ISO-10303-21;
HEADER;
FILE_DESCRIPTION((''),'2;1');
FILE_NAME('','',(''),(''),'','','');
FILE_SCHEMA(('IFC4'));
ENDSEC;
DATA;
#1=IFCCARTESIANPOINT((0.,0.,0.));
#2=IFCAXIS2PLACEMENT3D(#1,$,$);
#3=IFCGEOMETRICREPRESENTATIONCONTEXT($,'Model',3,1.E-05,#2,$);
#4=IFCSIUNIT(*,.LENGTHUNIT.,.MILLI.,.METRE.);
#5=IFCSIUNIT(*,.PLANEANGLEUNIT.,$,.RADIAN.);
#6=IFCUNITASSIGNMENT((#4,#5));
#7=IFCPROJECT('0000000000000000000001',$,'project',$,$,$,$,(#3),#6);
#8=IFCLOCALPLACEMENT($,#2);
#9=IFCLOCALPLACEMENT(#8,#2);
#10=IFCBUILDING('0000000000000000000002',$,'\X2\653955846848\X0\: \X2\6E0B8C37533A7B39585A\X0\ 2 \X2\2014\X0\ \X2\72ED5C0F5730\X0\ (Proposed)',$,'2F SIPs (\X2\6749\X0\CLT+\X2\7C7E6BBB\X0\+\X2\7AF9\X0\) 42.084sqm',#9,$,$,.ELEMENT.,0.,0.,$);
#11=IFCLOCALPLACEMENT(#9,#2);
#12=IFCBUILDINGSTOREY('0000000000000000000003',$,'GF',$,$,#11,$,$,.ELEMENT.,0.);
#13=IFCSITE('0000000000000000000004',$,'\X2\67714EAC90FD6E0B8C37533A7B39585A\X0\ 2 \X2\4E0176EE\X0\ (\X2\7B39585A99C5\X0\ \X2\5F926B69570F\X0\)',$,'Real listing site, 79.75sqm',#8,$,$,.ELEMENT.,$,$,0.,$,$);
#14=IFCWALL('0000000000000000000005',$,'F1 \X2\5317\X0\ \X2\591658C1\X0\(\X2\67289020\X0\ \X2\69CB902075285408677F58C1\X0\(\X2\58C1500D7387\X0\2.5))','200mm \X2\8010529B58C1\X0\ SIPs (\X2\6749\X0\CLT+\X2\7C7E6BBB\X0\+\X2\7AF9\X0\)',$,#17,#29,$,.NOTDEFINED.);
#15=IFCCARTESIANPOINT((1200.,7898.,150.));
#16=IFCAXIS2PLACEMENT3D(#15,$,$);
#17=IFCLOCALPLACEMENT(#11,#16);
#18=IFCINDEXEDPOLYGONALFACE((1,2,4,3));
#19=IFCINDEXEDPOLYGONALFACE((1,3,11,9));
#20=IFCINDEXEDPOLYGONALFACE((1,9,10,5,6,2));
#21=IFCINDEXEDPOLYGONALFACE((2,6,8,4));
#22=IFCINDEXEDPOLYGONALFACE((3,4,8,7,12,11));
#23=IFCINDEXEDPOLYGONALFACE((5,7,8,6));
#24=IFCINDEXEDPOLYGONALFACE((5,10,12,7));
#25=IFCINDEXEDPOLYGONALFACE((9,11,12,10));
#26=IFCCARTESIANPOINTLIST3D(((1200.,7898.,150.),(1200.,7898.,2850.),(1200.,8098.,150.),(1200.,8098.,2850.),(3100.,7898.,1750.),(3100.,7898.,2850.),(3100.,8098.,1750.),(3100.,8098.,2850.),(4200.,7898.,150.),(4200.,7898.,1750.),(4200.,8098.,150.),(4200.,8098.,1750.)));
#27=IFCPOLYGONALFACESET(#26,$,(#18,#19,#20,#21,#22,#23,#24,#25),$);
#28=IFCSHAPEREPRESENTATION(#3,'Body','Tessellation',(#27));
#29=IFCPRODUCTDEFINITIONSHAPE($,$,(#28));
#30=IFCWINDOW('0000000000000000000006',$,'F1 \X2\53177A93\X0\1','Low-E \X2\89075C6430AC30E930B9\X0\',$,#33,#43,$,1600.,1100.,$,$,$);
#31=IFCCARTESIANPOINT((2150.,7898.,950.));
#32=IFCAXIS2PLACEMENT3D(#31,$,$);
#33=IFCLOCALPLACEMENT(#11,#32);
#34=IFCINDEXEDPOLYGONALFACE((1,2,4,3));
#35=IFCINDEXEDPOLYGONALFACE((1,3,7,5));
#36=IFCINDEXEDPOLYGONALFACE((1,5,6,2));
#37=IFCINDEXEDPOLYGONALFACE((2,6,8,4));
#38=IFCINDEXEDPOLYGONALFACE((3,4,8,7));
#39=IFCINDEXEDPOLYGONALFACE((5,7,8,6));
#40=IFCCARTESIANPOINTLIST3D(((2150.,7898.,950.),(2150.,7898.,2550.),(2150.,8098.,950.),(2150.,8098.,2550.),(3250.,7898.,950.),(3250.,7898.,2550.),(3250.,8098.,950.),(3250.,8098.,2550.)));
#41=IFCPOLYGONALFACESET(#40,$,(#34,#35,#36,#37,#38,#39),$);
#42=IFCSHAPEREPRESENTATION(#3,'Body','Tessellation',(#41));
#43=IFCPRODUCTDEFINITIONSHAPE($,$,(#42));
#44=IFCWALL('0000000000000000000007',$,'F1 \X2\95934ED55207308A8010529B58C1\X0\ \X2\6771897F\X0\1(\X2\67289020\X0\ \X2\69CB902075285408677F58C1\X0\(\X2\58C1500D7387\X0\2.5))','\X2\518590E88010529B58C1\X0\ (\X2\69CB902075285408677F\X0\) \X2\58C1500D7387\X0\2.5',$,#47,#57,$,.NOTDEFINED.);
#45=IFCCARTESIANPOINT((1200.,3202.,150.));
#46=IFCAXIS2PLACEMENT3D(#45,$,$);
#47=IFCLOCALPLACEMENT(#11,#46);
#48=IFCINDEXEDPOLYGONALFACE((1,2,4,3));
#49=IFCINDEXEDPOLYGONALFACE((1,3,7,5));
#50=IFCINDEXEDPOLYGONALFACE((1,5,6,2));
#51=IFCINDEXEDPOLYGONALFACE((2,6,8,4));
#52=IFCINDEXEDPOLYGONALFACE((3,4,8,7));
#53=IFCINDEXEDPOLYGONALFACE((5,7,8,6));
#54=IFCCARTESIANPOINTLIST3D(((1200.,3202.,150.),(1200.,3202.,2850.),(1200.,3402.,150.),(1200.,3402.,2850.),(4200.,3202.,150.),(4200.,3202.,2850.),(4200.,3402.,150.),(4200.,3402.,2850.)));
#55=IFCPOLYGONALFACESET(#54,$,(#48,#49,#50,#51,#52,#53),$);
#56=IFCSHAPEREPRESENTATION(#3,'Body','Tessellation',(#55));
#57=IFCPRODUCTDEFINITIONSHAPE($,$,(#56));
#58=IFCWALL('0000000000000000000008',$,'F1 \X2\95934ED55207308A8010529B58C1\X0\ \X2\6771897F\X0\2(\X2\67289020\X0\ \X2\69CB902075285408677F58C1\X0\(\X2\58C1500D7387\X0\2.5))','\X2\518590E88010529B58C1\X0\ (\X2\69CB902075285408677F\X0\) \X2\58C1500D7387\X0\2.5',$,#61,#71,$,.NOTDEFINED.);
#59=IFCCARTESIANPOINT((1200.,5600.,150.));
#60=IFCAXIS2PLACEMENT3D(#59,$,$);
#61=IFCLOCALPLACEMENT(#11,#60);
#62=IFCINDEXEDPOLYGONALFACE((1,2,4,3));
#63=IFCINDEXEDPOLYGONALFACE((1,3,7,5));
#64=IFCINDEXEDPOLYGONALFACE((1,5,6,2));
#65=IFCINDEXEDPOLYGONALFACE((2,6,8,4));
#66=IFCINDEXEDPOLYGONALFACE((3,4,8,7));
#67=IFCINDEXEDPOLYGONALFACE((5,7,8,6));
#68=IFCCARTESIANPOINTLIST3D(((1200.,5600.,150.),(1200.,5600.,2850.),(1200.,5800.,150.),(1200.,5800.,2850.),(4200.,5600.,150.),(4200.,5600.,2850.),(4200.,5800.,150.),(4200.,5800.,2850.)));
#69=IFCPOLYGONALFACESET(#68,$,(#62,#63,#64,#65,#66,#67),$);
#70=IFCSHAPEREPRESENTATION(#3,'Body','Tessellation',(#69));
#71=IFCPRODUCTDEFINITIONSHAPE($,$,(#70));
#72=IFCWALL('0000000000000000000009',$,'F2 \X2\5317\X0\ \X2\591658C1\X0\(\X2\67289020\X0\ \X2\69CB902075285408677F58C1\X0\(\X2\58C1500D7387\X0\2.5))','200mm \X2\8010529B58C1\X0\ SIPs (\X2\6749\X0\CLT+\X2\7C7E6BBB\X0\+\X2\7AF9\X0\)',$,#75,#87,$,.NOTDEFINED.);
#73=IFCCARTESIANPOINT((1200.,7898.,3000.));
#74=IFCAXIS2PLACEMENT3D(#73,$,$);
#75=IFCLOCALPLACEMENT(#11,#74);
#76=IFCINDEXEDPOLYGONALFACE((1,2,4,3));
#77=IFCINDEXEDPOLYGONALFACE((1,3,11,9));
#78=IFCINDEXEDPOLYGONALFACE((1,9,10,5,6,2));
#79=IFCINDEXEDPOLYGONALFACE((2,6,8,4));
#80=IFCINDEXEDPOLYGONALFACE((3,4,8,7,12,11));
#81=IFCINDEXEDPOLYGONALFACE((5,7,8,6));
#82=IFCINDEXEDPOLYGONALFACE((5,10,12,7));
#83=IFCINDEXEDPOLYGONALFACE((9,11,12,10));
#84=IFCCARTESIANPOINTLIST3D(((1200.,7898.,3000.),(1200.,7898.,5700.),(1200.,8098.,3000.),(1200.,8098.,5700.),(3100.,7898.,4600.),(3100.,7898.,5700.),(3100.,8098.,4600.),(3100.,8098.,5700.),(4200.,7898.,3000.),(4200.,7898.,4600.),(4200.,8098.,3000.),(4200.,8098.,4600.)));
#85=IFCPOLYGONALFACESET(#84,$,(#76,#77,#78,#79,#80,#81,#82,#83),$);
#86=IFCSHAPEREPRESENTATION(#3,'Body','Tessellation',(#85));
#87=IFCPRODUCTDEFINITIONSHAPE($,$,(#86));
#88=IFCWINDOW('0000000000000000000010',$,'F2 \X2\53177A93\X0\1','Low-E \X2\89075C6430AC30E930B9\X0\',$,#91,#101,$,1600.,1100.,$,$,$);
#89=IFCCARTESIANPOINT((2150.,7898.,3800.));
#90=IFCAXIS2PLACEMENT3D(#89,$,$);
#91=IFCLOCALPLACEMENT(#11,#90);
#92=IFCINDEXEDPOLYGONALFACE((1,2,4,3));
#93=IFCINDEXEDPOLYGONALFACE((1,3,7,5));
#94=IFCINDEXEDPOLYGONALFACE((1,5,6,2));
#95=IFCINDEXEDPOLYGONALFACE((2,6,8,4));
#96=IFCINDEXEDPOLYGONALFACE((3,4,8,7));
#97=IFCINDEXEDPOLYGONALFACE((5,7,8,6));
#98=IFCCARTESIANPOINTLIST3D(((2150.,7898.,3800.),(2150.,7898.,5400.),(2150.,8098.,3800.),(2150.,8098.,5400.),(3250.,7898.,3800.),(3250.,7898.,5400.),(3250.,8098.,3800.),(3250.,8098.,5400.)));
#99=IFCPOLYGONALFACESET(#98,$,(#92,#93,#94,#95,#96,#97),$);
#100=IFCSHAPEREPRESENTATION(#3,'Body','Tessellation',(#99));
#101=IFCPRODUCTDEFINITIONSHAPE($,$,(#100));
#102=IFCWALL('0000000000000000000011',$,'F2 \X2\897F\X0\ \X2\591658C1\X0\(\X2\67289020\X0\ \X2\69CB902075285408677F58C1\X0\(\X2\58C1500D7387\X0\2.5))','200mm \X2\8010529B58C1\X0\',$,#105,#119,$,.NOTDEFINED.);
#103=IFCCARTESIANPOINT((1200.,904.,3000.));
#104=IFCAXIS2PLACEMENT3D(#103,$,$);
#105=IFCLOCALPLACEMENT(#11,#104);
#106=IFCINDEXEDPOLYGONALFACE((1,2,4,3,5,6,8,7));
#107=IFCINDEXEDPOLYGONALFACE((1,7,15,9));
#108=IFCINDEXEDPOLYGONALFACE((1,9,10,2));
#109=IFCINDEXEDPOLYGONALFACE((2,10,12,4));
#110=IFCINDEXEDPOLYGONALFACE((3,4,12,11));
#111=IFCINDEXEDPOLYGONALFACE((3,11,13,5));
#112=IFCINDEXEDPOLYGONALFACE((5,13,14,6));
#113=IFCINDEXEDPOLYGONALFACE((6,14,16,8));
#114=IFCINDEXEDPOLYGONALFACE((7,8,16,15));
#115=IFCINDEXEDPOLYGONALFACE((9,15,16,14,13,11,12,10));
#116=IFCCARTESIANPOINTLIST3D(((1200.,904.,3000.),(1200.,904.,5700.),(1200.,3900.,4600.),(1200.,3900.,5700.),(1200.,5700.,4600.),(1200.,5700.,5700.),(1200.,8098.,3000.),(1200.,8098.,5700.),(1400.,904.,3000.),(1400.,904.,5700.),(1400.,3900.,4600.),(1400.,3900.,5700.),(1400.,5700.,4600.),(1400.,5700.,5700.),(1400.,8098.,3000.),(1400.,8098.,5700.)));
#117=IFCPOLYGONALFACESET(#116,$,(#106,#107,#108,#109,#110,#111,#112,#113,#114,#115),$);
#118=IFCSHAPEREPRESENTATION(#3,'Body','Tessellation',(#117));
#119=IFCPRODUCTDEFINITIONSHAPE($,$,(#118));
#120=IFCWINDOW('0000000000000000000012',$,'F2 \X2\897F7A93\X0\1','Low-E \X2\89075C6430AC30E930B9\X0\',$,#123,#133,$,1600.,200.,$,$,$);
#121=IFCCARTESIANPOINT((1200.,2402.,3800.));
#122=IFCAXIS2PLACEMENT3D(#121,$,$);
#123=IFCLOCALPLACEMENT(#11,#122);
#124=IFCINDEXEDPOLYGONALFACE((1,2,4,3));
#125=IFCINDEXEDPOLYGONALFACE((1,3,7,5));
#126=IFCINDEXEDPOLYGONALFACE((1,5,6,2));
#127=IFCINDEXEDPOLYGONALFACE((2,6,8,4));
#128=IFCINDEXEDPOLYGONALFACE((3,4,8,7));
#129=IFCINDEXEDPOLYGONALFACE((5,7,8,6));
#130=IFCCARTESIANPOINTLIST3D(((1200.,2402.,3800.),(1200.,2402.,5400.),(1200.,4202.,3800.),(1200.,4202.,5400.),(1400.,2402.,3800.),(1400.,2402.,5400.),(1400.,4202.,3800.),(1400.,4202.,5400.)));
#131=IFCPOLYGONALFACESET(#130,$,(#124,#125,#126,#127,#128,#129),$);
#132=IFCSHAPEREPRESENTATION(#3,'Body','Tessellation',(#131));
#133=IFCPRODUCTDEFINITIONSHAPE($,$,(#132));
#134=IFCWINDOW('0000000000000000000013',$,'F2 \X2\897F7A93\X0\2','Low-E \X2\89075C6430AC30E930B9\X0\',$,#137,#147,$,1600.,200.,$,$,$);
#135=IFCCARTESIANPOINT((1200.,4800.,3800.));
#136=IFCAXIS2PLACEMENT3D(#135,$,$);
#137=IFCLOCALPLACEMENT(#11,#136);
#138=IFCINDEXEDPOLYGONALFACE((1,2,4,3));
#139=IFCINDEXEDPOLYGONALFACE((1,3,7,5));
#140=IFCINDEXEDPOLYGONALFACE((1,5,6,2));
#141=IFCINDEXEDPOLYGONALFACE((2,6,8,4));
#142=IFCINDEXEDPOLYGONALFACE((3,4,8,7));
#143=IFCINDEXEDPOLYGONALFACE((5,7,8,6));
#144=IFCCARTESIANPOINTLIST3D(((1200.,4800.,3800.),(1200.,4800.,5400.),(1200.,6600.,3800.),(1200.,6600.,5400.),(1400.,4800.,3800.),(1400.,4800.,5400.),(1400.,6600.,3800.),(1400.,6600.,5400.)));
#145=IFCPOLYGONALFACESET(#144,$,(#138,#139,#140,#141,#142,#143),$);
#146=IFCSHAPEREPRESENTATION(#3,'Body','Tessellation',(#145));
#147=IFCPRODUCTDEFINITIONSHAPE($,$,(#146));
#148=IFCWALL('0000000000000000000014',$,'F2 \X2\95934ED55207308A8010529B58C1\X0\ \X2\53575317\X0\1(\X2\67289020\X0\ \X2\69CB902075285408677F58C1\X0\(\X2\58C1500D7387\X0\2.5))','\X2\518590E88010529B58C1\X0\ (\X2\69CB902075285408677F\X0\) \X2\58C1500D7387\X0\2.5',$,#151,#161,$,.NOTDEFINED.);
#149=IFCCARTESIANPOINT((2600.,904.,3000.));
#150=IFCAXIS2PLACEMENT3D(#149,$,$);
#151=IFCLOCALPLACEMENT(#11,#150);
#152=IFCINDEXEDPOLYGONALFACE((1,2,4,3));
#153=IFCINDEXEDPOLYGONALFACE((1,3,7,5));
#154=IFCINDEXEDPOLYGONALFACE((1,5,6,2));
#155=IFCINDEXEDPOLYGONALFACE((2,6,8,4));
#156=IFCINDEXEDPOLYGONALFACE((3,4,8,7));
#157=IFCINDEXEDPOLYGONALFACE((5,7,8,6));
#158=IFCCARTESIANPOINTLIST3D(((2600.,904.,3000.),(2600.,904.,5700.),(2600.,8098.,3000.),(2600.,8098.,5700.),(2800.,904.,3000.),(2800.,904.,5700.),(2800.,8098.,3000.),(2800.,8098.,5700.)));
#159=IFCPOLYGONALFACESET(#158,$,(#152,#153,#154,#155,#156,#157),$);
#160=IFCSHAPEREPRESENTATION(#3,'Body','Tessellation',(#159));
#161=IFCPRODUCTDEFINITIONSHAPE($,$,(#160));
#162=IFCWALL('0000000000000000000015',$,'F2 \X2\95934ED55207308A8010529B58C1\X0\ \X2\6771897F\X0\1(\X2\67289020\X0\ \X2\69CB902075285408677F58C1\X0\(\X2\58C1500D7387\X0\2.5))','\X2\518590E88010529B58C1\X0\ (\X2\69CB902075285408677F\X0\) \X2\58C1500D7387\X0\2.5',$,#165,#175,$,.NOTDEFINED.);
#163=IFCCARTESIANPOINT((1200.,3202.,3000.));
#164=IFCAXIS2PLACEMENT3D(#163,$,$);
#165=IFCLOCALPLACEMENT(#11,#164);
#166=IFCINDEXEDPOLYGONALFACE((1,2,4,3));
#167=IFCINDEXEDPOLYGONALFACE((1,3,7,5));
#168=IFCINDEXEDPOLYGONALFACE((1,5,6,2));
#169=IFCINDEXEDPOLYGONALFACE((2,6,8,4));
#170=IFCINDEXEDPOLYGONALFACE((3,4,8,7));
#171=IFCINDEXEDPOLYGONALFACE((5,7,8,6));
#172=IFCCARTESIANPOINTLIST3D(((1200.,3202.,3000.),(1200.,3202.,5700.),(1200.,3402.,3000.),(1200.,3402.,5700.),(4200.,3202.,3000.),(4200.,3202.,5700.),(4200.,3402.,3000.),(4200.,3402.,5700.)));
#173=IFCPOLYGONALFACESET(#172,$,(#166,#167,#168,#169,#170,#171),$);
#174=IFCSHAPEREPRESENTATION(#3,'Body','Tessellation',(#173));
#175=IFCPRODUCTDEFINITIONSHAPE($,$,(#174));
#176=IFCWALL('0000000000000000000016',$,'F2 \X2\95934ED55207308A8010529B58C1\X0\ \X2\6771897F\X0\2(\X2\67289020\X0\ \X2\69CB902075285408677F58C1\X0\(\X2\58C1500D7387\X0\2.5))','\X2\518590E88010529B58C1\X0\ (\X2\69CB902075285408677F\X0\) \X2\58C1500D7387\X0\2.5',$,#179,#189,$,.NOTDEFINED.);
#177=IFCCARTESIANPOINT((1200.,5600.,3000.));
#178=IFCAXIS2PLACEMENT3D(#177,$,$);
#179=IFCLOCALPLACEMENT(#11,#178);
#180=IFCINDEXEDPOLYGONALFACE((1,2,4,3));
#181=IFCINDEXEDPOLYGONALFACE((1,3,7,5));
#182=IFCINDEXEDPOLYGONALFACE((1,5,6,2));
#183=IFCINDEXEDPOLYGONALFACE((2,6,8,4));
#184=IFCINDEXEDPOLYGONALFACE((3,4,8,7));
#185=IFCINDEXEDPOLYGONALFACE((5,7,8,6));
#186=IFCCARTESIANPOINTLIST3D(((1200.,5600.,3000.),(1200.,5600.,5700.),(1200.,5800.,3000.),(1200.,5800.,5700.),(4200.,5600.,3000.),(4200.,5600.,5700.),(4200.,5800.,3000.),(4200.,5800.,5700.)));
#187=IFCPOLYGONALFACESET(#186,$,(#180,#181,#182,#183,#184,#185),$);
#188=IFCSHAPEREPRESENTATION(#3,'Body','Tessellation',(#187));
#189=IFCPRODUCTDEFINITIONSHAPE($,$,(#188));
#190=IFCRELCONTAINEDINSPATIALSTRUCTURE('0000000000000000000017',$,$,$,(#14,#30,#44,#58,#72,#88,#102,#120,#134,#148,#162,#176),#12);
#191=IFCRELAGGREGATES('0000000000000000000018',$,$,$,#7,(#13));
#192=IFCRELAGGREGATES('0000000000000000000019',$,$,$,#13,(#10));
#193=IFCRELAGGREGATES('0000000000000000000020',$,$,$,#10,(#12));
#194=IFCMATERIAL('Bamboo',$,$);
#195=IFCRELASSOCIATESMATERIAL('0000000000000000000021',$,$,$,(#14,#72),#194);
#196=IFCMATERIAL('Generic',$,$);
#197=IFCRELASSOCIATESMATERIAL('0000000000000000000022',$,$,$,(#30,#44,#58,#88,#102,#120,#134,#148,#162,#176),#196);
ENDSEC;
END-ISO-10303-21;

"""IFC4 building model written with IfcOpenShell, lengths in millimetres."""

from ifc_helpers import new_model, si_unit, frame, frame_2d, origin, place, context, project, spatial, rectangle, extrude, material, element, fill, save


model = new_model("IFC4")

# Units and contexts
model_context = context("Model", 3, precision=1e-05, world=origin())
ifc_project = project(units=[si_unit("LENGTHUNIT", "METRE", prefix="MILLI"), si_unit("PLANEANGLEUNIT", "RADIAN")], contexts=[model_context])

# Site, building, storey
site_placement = place(None, origin())
site = spatial("IfcSite", under=ifc_project, at=site_placement, Name="東京都渋谷区笹塚 2 丁目 (笹塚駅 徒歩圏)", ObjectType="Real listing site, 79.75sqm", CompositionType="ELEMENT", RefElevation=0.0)
building_placement = place(site_placement, origin())
building = spatial("IfcBuilding", under=site, at=building_placement, Name="改善案: 渋谷区笹塚 2 — 狭小地 (Proposed)", ObjectType="2F SIPs (杉CLT+籾殻+竹) 42.084sqm", CompositionType="ELEMENT", ElevationOfRefHeight=0.0, ElevationOfTerrain=0.0)
storey_placement = place(building_placement, origin())
storey = spatial("IfcBuildingStorey", under=building, at=storey_placement, Name="GF", CompositionType="ELEMENT", Elevation=0.0)

# Wall, opening, window
ifc_material_1 = material(Name="Bamboo")
wall_1_placement = place(storey_placement, frame((1200.0, 7898.0, 150.0)))
wall_1 = element("IfcWall", 1, at=wall_1_placement, inside=storey, material=ifc_material_1, Name="F1 北 外壁(木造 構造用合板壁(壁倍率2.5))", Description="200mm 耐力壁 SIPs (杉CLT+籾殻+竹)", PredefinedType="NOTDEFINED", context=model_context, shape_type="SweptSolid", body=[
    extrude(rectangle(XDim=3000.0, YDim=200.0, at=frame_2d((1500.0, 100.0))), frame((1200.0, 7898.0, 150.0)), (0.0, 0.0, 1.0), 2700.0),
])
opening_1_placement = place(storey_placement, frame((2150.0, 7898.0, 950.0)))
opening_1 = element("IfcOpeningElement", 2, at=opening_1_placement, cuts=wall_1, PredefinedType="NOTDEFINED", context=model_context, shape_type="SweptSolid", body=[
    extrude(rectangle(XDim=1100.0, YDim=200.0, at=frame_2d((550.0, 100.0))), frame((2150.0, 7898.0, 950.0)), (0.0, 0.0, 1.0), 1600.0),
])
ifc_material_2 = material(Name="Generic")
window_1_placement = place(storey_placement, frame((2150.0, 7898.0, 950.0)))
window_1 = element("IfcWindow", 3, at=window_1_placement, inside=storey, material=ifc_material_2, Name="F1 北窓1", Description="Low-E 複層ガラス", OverallHeight=1600.0, OverallWidth=1100.0, context=model_context, shape_type="SweptSolid", body=[
    extrude(rectangle(XDim=1100.0, YDim=200.0, at=frame_2d((550.0, 100.0))), frame((2150.0, 7898.0, 950.0)), (0.0, 0.0, 1.0), 1600.0),
])
fill(opening_1, window_1)

# Walls
wall_2_placement = place(storey_placement, frame((1200.0, 3202.0, 150.0)))
element("IfcWall", 4, at=wall_2_placement, inside=storey, material=ifc_material_2, Name="F1 間仕切り耐力壁 東西1(木造 構造用合板壁(壁倍率2.5))", Description="内部耐力壁 (構造用合板) 壁倍率2.5", PredefinedType="NOTDEFINED", context=model_context, shape_type="SweptSolid", body=[
    extrude(rectangle(XDim=3000.0, YDim=200.0, at=frame_2d((1500.0, 100.0))), frame((1200.0, 3202.0, 150.0)), (0.0, 0.0, 1.0), 2700.0),
])
wall_3_placement = place(storey_placement, frame((1200.0, 5600.0, 150.0)))
element("IfcWall", 5, at=wall_3_placement, inside=storey, material=ifc_material_2, Name="F1 間仕切り耐力壁 東西2(木造 構造用合板壁(壁倍率2.5))", Description="内部耐力壁 (構造用合板) 壁倍率2.5", PredefinedType="NOTDEFINED", context=model_context, shape_type="SweptSolid", body=[
    extrude(rectangle(XDim=3000.0, YDim=200.0, at=frame_2d((1500.0, 100.0))), frame((1200.0, 5600.0, 150.0)), (0.0, 0.0, 1.0), 2700.0),
])

# Wall, opening, window
wall_4_placement = place(storey_placement, frame((1200.0, 7898.0, 3000.0)))
wall_4 = element("IfcWall", 6, at=wall_4_placement, inside=storey, material=ifc_material_1, Name="F2 北 外壁(木造 構造用合板壁(壁倍率2.5))", Description="200mm 耐力壁 SIPs (杉CLT+籾殻+竹)", PredefinedType="NOTDEFINED", context=model_context, shape_type="SweptSolid", body=[
    extrude(rectangle(XDim=3000.0, YDim=200.0, at=frame_2d((1500.0, 100.0))), frame((1200.0, 7898.0, 3000.0)), (0.0, 0.0, 1.0), 2700.0),
])
opening_2_placement = place(storey_placement, frame((2150.0, 7898.0, 3800.0)))
opening_2 = element("IfcOpeningElement", 7, at=opening_2_placement, cuts=wall_4, PredefinedType="NOTDEFINED", context=model_context, shape_type="SweptSolid", body=[
    extrude(rectangle(XDim=1100.0, YDim=200.0, at=frame_2d((550.0, 100.0))), frame((2150.0, 7898.0, 3800.0)), (0.0, 0.0, 1.0), 1600.0),
])
window_2_placement = place(storey_placement, frame((2150.0, 7898.0, 3800.0)))
window_2 = element("IfcWindow", 8, at=window_2_placement, inside=storey, material=ifc_material_2, Name="F2 北窓1", Description="Low-E 複層ガラス", OverallHeight=1600.0, OverallWidth=1100.0, context=model_context, shape_type="SweptSolid", body=[
    extrude(rectangle(XDim=1100.0, YDim=200.0, at=frame_2d((550.0, 100.0))), frame((2150.0, 7898.0, 3800.0)), (0.0, 0.0, 1.0), 1600.0),
])
fill(opening_2, window_2)

# Wall, openings, windows
wall_5_placement = place(storey_placement, frame((1200.0, 904.0, 3000.0)))
wall_5 = element("IfcWall", 9, at=wall_5_placement, inside=storey, material=ifc_material_2, Name="F2 西 外壁(木造 構造用合板壁(壁倍率2.5))", Description="200mm 耐力壁", PredefinedType="NOTDEFINED", context=model_context, shape_type="SweptSolid", body=[
    extrude(rectangle(XDim=200.0, YDim=7194.0, at=frame_2d((100.0, 3597.0))), frame((1200.0, 904.0, 3000.0)), (0.0, 0.0, 1.0), 2700.0),
])
opening_3_placement = place(storey_placement, frame((1200.0, 2402.0, 3800.0)))
opening_3 = element("IfcOpeningElement", 10, at=opening_3_placement, cuts=wall_5, PredefinedType="NOTDEFINED", context=model_context, shape_type="SweptSolid", body=[
    extrude(rectangle(XDim=200.0, YDim=1800.0, at=frame_2d((100.0, 900.0))), frame((1200.0, 2402.0, 3800.0)), (0.0, 0.0, 1.0), 1600.0),
])
opening_4_placement = place(storey_placement, frame((1200.0, 4800.0, 3800.0)))
opening_4 = element("IfcOpeningElement", 11, at=opening_4_placement, cuts=wall_5, PredefinedType="NOTDEFINED", context=model_context, shape_type="SweptSolid", body=[
    extrude(rectangle(XDim=200.0, YDim=1800.0, at=frame_2d((100.0, 900.0))), frame((1200.0, 4800.0, 3800.0)), (0.0, 0.0, 1.0), 1600.0),
])
window_3_placement = place(storey_placement, frame((1200.0, 2402.0, 3800.0)))
window_3 = element("IfcWindow", 12, at=window_3_placement, inside=storey, material=ifc_material_2, Name="F2 西窓1", Description="Low-E 複層ガラス", OverallHeight=1600.0, OverallWidth=200.0, context=model_context, shape_type="SweptSolid", body=[
    extrude(rectangle(XDim=200.0, YDim=1800.0, at=frame_2d((100.0, 900.0))), frame((1200.0, 2402.0, 3800.0)), (0.0, 0.0, 1.0), 1600.0),
])
fill(opening_3, window_3)
window_4_placement = place(storey_placement, frame((1200.0, 4800.0, 3800.0)))
window_4 = element("IfcWindow", 13, at=window_4_placement, inside=storey, material=ifc_material_2, Name="F2 西窓2", Description="Low-E 複層ガラス", OverallHeight=1600.0, OverallWidth=200.0, context=model_context, shape_type="SweptSolid", body=[
    extrude(rectangle(XDim=200.0, YDim=1800.0, at=frame_2d((100.0, 900.0))), frame((1200.0, 4800.0, 3800.0)), (0.0, 0.0, 1.0), 1600.0),
])
fill(opening_4, window_4)

# Walls
wall_6_placement = place(storey_placement, frame((2600.0, 904.0, 3000.0)))
element("IfcWall", 14, at=wall_6_placement, inside=storey, material=ifc_material_2, Name="F2 間仕切り耐力壁 南北1(木造 構造用合板壁(壁倍率2.5))", Description="内部耐力壁 (構造用合板) 壁倍率2.5", PredefinedType="NOTDEFINED", context=model_context, shape_type="SweptSolid", body=[
    extrude(rectangle(XDim=200.0, YDim=7194.0, at=frame_2d((100.0, 3597.0))), frame((2600.0, 904.0, 3000.0)), (0.0, 0.0, 1.0), 2700.0),
])
wall_7_placement = place(storey_placement, frame((1200.0, 3202.0, 3000.0)))
element("IfcWall", 15, at=wall_7_placement, inside=storey, material=ifc_material_2, Name="F2 間仕切り耐力壁 東西1(木造 構造用合板壁(壁倍率2.5))", Description="内部耐力壁 (構造用合板) 壁倍率2.5", PredefinedType="NOTDEFINED", context=model_context, shape_type="SweptSolid", body=[
    extrude(rectangle(XDim=3000.0, YDim=200.0, at=frame_2d((1500.0, 100.0))), frame((1200.0, 3202.0, 3000.0)), (0.0, 0.0, 1.0), 2700.0),
])
wall_8_placement = place(storey_placement, frame((1200.0, 5600.0, 3000.0)))
element("IfcWall", 16, at=wall_8_placement, inside=storey, material=ifc_material_2, Name="F2 間仕切り耐力壁 東西2(木造 構造用合板壁(壁倍率2.5))", Description="内部耐力壁 (構造用合板) 壁倍率2.5", PredefinedType="NOTDEFINED", context=model_context, shape_type="SweptSolid", body=[
    extrude(rectangle(XDim=3000.0, YDim=200.0, at=frame_2d((1500.0, 100.0))), frame((1200.0, 5600.0, 3000.0)), (0.0, 0.0, 1.0), 2700.0),
])

save(model, "model.ifc")
